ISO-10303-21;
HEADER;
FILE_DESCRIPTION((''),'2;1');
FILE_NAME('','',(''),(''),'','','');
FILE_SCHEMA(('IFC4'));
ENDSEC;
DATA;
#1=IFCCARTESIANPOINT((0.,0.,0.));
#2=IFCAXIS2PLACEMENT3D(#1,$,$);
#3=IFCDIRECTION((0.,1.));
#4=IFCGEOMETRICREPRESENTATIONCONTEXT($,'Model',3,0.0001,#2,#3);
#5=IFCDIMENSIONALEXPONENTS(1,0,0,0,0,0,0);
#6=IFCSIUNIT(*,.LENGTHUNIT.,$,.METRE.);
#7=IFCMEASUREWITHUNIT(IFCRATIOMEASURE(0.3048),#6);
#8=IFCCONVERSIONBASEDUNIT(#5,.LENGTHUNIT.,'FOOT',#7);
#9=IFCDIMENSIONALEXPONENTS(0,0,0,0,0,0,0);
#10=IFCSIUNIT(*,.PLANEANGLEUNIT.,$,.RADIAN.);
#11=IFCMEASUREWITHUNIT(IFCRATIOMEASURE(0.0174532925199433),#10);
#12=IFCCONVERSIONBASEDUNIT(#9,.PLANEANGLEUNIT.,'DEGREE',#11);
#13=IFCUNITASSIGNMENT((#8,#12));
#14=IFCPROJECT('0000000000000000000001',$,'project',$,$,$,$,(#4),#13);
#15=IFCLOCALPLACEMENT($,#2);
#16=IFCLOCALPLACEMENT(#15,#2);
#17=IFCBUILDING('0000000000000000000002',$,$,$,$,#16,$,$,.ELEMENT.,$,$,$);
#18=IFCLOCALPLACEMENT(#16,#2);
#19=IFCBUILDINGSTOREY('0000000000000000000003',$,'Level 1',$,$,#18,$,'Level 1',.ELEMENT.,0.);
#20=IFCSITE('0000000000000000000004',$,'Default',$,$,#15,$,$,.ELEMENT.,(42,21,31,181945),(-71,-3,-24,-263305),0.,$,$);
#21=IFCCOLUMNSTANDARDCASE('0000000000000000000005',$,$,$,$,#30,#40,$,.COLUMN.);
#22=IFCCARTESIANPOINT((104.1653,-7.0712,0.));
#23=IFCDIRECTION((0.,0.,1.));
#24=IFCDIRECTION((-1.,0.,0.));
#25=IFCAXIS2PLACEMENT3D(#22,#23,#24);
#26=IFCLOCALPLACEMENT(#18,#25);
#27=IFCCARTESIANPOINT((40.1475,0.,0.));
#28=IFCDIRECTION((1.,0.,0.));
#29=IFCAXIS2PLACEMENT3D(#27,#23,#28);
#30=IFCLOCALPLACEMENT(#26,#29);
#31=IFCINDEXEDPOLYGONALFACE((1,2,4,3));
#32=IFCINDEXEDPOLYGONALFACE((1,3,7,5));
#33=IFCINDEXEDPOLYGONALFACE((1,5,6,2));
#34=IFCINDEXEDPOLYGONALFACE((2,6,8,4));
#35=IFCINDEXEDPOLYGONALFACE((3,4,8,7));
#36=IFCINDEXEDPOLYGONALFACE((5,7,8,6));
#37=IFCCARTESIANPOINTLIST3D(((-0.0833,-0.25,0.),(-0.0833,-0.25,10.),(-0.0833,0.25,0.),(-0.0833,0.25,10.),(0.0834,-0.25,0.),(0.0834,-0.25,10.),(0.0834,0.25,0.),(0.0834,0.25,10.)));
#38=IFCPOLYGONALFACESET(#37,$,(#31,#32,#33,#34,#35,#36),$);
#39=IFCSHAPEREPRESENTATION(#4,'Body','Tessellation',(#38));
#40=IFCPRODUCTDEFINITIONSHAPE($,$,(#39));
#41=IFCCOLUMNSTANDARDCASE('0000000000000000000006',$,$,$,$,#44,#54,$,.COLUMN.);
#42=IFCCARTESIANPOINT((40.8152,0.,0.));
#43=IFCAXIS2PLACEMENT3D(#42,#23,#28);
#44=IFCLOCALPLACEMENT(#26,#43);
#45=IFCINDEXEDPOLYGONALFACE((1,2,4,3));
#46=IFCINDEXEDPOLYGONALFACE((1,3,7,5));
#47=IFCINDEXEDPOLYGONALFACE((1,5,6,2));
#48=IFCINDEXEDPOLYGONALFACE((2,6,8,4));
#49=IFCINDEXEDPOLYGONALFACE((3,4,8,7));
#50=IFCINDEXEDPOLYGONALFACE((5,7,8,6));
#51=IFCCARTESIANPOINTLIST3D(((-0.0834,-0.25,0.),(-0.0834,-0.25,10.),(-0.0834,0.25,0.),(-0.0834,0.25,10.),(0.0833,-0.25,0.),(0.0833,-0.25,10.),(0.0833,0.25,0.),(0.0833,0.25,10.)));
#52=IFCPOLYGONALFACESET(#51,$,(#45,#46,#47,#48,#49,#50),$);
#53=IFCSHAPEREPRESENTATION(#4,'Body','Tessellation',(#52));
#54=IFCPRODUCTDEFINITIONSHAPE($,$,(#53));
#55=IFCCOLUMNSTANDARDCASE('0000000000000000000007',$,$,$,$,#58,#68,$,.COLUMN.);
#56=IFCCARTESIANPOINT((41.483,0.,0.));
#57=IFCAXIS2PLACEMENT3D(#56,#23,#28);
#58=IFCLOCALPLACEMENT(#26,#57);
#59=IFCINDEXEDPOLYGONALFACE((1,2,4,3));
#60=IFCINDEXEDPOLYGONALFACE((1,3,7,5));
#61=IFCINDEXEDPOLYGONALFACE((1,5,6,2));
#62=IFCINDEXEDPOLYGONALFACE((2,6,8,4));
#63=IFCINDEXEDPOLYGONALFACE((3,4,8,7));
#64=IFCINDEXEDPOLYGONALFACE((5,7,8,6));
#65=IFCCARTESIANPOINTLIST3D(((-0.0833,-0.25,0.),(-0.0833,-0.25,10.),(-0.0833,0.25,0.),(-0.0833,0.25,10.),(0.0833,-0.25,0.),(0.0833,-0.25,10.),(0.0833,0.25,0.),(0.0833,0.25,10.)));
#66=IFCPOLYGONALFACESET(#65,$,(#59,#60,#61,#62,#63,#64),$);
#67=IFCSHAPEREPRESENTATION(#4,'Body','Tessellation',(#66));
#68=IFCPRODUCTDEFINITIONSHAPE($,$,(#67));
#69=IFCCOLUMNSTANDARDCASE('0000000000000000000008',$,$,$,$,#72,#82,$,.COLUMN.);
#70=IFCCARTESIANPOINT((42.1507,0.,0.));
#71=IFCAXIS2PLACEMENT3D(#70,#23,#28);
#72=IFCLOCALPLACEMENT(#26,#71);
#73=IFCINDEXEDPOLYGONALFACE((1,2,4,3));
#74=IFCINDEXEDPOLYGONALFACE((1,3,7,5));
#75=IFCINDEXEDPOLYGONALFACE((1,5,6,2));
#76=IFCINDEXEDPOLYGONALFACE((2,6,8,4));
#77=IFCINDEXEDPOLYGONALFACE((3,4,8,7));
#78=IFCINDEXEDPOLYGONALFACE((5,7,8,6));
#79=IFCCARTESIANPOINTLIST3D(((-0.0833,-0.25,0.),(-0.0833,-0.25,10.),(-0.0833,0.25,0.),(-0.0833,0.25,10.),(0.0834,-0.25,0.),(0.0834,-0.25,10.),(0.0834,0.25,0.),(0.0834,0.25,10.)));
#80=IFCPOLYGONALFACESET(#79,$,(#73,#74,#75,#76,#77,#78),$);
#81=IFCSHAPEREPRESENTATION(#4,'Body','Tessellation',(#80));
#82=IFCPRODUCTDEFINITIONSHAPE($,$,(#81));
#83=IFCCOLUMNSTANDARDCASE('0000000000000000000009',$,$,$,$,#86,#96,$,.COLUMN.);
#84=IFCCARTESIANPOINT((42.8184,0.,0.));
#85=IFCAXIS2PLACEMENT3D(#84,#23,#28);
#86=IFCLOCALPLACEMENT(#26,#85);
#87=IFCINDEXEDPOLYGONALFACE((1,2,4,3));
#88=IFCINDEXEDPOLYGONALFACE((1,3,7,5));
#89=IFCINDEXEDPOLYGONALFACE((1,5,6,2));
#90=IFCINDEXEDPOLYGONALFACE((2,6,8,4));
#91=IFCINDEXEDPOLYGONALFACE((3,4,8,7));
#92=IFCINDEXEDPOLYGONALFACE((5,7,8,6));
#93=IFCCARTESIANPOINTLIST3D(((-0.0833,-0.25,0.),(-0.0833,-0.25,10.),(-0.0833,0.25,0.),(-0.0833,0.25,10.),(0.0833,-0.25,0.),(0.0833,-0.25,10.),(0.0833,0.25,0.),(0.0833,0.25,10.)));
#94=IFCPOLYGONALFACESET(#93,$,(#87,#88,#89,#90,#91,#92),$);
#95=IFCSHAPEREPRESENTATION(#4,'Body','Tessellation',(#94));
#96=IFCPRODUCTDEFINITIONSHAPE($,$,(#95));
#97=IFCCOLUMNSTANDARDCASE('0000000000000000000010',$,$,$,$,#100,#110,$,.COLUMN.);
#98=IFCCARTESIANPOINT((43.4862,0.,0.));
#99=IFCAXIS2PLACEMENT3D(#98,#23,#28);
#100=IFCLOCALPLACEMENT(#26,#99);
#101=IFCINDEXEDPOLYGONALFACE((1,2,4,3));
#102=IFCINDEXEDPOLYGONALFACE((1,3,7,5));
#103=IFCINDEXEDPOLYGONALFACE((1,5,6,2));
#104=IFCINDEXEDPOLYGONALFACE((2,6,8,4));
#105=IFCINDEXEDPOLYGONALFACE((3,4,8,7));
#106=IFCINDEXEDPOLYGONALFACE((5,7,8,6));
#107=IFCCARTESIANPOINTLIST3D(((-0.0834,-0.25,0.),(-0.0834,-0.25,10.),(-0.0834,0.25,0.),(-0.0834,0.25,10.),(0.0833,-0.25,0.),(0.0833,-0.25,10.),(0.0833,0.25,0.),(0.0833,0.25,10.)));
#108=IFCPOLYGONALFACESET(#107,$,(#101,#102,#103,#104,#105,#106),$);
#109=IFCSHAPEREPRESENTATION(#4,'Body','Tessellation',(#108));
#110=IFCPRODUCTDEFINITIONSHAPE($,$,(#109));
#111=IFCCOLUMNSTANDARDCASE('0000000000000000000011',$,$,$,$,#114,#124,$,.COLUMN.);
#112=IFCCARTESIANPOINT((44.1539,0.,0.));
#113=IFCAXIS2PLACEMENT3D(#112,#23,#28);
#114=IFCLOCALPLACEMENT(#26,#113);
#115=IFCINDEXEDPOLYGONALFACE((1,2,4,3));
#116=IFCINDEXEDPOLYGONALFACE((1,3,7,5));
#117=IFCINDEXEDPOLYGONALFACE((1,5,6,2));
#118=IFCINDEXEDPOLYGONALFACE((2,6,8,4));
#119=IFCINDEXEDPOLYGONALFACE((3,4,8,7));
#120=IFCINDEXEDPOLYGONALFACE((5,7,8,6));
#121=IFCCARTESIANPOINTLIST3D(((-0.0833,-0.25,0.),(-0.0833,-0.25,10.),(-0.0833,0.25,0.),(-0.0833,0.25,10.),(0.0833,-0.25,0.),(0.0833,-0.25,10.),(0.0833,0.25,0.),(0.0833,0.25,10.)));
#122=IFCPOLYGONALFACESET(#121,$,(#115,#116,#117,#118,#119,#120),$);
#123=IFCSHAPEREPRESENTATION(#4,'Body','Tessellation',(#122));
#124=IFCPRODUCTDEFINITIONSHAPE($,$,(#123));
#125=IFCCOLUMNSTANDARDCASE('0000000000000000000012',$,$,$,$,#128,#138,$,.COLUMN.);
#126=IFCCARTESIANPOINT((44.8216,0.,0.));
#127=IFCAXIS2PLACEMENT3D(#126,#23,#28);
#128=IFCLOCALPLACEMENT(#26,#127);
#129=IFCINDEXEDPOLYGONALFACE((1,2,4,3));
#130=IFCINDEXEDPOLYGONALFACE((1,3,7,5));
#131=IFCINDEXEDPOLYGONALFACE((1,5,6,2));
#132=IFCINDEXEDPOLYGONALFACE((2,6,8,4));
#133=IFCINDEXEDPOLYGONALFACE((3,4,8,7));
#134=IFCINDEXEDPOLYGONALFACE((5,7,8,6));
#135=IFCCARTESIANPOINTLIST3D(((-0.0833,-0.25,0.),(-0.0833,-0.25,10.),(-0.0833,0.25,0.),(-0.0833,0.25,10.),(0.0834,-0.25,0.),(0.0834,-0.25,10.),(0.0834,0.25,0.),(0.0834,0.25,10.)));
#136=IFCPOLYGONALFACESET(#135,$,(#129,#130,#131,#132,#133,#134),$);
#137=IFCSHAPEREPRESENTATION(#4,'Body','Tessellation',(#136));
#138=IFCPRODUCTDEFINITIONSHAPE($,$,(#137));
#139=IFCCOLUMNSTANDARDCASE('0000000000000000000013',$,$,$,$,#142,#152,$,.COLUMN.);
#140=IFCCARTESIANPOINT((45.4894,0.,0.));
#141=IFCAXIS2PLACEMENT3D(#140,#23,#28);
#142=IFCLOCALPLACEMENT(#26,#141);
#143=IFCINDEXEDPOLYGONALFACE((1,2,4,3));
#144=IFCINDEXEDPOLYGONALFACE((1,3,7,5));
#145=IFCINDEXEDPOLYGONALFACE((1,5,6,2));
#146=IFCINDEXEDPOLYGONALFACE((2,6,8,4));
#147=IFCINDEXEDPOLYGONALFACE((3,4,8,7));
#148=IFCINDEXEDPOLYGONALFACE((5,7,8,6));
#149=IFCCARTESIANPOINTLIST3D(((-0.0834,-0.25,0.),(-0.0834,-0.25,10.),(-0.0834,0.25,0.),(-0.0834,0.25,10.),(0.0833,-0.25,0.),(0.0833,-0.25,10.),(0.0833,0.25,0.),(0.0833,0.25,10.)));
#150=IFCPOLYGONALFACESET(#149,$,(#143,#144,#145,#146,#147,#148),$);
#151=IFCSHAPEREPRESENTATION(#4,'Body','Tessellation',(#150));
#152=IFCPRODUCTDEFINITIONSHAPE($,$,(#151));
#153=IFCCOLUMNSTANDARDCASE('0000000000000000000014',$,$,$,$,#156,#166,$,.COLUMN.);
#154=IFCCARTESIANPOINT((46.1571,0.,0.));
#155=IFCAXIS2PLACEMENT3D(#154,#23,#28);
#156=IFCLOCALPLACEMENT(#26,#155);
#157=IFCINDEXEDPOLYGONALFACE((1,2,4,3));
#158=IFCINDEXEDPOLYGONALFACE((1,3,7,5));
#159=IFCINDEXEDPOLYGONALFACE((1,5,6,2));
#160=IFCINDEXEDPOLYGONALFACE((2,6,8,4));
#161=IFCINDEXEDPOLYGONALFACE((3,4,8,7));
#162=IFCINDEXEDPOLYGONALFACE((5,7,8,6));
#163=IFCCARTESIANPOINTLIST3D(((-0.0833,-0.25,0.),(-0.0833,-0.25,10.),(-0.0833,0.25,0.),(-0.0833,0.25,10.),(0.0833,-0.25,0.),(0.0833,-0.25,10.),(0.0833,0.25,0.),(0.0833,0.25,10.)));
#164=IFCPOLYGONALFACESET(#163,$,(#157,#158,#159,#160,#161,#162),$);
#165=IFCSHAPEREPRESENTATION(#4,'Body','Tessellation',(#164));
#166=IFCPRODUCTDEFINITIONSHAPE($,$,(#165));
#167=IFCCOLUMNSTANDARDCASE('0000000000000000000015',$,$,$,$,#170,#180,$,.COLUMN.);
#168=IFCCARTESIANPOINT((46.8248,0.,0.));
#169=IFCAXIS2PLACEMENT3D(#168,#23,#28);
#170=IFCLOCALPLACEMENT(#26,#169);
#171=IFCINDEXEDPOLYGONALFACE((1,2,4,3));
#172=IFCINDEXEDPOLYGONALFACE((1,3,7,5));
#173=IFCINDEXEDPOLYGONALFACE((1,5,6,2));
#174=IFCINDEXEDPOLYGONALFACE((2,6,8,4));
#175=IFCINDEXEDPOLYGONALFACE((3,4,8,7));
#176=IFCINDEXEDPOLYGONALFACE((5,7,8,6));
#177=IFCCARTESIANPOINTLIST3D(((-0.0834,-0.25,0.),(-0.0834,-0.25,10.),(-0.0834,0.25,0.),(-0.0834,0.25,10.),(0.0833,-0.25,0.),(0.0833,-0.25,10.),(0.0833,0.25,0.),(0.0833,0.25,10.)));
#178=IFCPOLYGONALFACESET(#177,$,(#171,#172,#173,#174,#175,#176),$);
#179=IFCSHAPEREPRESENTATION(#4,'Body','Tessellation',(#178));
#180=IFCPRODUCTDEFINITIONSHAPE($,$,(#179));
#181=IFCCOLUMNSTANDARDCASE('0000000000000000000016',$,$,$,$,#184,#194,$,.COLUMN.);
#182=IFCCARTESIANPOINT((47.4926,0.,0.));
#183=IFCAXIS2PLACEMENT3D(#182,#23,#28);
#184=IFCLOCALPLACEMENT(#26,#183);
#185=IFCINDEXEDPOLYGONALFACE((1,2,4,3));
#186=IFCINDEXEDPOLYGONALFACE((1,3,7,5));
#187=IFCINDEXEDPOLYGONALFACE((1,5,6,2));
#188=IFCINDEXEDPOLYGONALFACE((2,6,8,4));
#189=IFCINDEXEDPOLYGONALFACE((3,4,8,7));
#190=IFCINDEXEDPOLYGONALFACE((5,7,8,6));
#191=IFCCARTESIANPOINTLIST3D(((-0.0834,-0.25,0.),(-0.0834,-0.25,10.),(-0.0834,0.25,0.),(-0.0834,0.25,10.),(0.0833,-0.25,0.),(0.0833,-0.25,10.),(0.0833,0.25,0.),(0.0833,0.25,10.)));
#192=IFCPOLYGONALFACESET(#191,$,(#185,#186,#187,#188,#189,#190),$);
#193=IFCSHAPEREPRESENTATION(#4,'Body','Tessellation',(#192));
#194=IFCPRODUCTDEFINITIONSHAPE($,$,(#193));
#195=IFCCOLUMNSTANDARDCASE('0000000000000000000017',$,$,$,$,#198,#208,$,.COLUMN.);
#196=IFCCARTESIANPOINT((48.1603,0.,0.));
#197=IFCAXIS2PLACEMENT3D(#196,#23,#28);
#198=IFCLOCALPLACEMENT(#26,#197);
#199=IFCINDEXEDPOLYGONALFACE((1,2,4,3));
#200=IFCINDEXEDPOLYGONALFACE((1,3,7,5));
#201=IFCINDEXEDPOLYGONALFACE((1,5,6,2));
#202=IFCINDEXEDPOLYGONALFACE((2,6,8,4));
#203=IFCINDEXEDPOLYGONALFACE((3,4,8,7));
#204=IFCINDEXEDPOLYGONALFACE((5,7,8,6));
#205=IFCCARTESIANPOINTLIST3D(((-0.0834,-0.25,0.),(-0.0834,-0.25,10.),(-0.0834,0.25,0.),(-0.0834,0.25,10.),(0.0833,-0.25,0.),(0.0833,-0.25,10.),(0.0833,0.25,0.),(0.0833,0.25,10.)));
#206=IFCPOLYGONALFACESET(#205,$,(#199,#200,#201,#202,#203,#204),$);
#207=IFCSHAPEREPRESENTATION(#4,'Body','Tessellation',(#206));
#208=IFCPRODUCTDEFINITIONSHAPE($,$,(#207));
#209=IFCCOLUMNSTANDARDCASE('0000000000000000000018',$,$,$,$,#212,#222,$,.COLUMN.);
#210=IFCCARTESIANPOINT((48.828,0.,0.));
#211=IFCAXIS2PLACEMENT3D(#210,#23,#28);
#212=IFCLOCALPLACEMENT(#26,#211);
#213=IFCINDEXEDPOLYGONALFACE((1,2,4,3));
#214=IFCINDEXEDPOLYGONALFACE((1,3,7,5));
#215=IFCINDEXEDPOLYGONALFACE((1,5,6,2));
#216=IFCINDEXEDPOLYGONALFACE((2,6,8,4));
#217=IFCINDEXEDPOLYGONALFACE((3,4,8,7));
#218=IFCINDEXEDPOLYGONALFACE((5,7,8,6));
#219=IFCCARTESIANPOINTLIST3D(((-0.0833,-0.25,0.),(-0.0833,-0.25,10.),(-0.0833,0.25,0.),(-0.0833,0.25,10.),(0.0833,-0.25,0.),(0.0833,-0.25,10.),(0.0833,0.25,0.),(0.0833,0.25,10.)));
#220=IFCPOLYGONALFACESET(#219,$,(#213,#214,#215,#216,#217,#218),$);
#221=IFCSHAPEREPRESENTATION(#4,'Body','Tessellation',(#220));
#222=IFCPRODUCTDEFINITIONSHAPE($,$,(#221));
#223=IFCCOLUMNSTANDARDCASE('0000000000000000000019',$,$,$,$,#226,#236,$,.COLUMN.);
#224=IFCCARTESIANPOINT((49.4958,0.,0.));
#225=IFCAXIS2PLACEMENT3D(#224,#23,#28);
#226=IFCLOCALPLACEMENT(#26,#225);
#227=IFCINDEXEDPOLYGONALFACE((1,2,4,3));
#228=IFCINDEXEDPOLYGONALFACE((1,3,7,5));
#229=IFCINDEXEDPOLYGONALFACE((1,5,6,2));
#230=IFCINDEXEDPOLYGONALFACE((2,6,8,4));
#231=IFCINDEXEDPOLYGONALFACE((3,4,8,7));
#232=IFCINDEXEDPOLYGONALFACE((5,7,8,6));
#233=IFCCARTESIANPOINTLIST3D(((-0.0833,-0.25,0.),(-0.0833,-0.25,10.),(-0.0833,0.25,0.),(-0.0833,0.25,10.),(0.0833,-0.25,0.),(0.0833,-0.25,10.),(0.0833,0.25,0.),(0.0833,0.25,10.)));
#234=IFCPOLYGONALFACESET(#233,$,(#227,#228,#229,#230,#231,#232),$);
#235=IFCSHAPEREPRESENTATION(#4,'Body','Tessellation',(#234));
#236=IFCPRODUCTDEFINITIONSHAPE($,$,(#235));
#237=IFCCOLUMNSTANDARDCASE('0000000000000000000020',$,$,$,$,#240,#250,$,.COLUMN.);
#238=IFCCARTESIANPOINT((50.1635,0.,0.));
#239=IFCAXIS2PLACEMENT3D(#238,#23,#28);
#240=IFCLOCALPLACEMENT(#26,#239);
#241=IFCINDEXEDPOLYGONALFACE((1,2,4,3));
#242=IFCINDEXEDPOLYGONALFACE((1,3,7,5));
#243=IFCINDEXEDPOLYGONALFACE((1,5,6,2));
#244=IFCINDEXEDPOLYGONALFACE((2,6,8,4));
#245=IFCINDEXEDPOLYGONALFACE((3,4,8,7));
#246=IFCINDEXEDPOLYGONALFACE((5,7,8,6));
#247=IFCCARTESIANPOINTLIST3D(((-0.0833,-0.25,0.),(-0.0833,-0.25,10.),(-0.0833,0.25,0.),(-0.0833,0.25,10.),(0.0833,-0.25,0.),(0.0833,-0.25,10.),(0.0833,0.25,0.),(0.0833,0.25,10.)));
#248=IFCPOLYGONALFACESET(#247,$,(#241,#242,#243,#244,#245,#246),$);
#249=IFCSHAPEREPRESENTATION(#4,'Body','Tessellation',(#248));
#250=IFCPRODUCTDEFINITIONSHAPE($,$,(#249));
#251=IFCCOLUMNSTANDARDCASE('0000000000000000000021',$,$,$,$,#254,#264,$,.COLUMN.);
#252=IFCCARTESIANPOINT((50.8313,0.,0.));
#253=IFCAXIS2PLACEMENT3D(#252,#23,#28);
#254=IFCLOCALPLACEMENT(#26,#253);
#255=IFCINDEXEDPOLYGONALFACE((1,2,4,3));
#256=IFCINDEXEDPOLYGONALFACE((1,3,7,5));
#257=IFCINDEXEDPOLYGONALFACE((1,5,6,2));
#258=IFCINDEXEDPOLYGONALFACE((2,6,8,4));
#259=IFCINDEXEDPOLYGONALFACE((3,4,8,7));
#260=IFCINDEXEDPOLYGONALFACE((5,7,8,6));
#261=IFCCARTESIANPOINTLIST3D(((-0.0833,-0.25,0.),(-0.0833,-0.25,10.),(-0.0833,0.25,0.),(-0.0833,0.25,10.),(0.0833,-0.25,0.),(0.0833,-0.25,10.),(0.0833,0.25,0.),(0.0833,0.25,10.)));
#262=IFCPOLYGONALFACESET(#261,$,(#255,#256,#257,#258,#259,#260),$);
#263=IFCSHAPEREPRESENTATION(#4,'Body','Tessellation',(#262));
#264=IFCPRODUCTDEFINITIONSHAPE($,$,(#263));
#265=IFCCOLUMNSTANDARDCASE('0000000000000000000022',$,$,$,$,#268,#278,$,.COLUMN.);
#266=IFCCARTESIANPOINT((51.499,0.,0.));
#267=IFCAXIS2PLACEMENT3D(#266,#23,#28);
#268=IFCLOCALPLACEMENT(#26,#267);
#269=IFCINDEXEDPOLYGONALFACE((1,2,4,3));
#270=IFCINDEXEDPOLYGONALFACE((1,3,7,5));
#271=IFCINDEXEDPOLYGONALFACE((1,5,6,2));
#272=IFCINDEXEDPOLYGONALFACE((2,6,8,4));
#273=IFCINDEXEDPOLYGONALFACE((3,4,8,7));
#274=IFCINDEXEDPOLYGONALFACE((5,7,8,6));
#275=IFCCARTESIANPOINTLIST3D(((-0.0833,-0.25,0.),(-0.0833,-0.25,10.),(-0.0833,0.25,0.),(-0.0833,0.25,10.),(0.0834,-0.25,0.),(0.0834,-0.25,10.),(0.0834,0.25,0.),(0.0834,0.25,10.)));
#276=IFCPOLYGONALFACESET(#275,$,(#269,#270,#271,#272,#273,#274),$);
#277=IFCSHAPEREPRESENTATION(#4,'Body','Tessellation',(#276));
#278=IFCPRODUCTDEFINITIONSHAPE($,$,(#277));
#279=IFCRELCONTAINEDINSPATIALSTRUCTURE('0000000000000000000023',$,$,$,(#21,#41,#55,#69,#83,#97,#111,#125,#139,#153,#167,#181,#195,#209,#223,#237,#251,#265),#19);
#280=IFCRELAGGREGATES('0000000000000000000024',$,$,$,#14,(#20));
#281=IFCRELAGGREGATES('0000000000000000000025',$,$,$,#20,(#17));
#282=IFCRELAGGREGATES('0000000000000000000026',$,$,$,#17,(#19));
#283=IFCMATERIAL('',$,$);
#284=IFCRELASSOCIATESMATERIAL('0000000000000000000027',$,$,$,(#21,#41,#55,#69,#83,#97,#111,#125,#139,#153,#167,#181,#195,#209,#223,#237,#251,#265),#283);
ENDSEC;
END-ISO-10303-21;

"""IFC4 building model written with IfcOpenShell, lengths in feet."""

from ifc_helpers import new_model, entity, si_unit, converted_unit, direction, frame, origin, place, context, project, spatial, rectangle, extrude, material, element, save


model = new_model("IFC4")

# Units and contexts
model_context = context("Model", 3, precision=0.0001, world=origin(), true_north=direction((0.0, 1.0)))
ifc_project = project(units=[converted_unit("LENGTHUNIT", "FOOT", entity("IfcRatioMeasure", 0.3048), si_unit("LENGTHUNIT", "METRE"), dimensions=[1, 0, 0, 0, 0, 0, 0]), converted_unit("PLANEANGLEUNIT", "DEGREE", entity("IfcRatioMeasure", 0.0174532925199433), si_unit("PLANEANGLEUNIT", "RADIAN"), dimensions=[0, 0, 0, 0, 0, 0, 0])], contexts=[model_context])

# Site, building, storey
site_placement = place(None, origin())
site = spatial("IfcSite", under=ifc_project, at=site_placement, Name="Default", CompositionType="ELEMENT", RefLatitude=(42, 21, 31, 181945), RefLongitude=(-71, -3, -24, -263305), RefElevation=0.0)
building_placement = place(site_placement, origin())
building = spatial("IfcBuilding", under=site, at=building_placement, CompositionType="ELEMENT")
storey_placement = place(building_placement, origin())
storey = spatial("IfcBuildingStorey", under=building, at=storey_placement, Name="Level 1", LongName="Level 1", CompositionType="ELEMENT", Elevation=0.0)

# Columns
ifc_material_1 = material(Name="")
placement_1 = place(storey_placement, frame((104.1653, -7.0712, 0.0), z_axis=(0.0, 0.0, 1.0), x_axis=(-1.0, 0.0, 0.0)))
for number, where, z_axis, x_axis in (
    (1, (40.1475, 0.0, 0.0), (0.0, 0.0, 1.0), (1.0, 0.0, 0.0)),
    (2, (40.8152, 0.0, 0.0), (0.0, 0.0, 1.0), (1.0, 0.0, 0.0)),
    (3, (41.483, 0.0, 0.0), (0.0, 0.0, 1.0), (1.0, 0.0, 0.0)),
    (4, (42.1507, 0.0, 0.0), (0.0, 0.0, 1.0), (1.0, 0.0, 0.0)),
    (5, (42.8184, 0.0, 0.0), (0.0, 0.0, 1.0), (1.0, 0.0, 0.0)),
    (6, (43.4862, 0.0, 0.0), (0.0, 0.0, 1.0), (1.0, 0.0, 0.0)),
    (7, (44.1539, 0.0, 0.0), (0.0, 0.0, 1.0), (1.0, 0.0, 0.0)),
    (8, (44.8216, 0.0, 0.0), (0.0, 0.0, 1.0), (1.0, 0.0, 0.0)),
    (9, (45.4894, 0.0, 0.0), (0.0, 0.0, 1.0), (1.0, 0.0, 0.0)),
    (10, (46.1571, 0.0, 0.0), (0.0, 0.0, 1.0), (1.0, 0.0, 0.0)),
    (11, (46.8248, 0.0, 0.0), (0.0, 0.0, 1.0), (1.0, 0.0, 0.0)),
    (12, (47.4926, 0.0, 0.0), (0.0, 0.0, 1.0), (1.0, 0.0, 0.0)),
    (13, (48.1603, 0.0, 0.0), (0.0, 0.0, 1.0), (1.0, 0.0, 0.0)),
    (14, (48.828, 0.0, 0.0), (0.0, 0.0, 1.0), (1.0, 0.0, 0.0)),
    (15, (49.4958, 0.0, 0.0), (0.0, 0.0, 1.0), (1.0, 0.0, 0.0)),
    (16, (50.1635, 0.0, 0.0), (0.0, 0.0, 1.0), (1.0, 0.0, 0.0)),
    (17, (50.8313, 0.0, 0.0), (0.0, 0.0, 1.0), (1.0, 0.0, 0.0)),
    (18, (51.499, 0.0, 0.0), (0.0, 0.0, 1.0), (1.0, 0.0, 0.0)),
):
    element("IfcColumnStandardCase", number, at=place(placement_1, frame(where, z_axis=z_axis, x_axis=x_axis)), inside=storey, material=ifc_material_1, PredefinedType="COLUMN", context=model_context, shape_type="SweptSolid", body=[
        extrude(rectangle(XDim=0.1667, YDim=0.5), origin(), (0.0, 0.0, 1.0), 10.0),
    ])

save(model, "model.ifc")
